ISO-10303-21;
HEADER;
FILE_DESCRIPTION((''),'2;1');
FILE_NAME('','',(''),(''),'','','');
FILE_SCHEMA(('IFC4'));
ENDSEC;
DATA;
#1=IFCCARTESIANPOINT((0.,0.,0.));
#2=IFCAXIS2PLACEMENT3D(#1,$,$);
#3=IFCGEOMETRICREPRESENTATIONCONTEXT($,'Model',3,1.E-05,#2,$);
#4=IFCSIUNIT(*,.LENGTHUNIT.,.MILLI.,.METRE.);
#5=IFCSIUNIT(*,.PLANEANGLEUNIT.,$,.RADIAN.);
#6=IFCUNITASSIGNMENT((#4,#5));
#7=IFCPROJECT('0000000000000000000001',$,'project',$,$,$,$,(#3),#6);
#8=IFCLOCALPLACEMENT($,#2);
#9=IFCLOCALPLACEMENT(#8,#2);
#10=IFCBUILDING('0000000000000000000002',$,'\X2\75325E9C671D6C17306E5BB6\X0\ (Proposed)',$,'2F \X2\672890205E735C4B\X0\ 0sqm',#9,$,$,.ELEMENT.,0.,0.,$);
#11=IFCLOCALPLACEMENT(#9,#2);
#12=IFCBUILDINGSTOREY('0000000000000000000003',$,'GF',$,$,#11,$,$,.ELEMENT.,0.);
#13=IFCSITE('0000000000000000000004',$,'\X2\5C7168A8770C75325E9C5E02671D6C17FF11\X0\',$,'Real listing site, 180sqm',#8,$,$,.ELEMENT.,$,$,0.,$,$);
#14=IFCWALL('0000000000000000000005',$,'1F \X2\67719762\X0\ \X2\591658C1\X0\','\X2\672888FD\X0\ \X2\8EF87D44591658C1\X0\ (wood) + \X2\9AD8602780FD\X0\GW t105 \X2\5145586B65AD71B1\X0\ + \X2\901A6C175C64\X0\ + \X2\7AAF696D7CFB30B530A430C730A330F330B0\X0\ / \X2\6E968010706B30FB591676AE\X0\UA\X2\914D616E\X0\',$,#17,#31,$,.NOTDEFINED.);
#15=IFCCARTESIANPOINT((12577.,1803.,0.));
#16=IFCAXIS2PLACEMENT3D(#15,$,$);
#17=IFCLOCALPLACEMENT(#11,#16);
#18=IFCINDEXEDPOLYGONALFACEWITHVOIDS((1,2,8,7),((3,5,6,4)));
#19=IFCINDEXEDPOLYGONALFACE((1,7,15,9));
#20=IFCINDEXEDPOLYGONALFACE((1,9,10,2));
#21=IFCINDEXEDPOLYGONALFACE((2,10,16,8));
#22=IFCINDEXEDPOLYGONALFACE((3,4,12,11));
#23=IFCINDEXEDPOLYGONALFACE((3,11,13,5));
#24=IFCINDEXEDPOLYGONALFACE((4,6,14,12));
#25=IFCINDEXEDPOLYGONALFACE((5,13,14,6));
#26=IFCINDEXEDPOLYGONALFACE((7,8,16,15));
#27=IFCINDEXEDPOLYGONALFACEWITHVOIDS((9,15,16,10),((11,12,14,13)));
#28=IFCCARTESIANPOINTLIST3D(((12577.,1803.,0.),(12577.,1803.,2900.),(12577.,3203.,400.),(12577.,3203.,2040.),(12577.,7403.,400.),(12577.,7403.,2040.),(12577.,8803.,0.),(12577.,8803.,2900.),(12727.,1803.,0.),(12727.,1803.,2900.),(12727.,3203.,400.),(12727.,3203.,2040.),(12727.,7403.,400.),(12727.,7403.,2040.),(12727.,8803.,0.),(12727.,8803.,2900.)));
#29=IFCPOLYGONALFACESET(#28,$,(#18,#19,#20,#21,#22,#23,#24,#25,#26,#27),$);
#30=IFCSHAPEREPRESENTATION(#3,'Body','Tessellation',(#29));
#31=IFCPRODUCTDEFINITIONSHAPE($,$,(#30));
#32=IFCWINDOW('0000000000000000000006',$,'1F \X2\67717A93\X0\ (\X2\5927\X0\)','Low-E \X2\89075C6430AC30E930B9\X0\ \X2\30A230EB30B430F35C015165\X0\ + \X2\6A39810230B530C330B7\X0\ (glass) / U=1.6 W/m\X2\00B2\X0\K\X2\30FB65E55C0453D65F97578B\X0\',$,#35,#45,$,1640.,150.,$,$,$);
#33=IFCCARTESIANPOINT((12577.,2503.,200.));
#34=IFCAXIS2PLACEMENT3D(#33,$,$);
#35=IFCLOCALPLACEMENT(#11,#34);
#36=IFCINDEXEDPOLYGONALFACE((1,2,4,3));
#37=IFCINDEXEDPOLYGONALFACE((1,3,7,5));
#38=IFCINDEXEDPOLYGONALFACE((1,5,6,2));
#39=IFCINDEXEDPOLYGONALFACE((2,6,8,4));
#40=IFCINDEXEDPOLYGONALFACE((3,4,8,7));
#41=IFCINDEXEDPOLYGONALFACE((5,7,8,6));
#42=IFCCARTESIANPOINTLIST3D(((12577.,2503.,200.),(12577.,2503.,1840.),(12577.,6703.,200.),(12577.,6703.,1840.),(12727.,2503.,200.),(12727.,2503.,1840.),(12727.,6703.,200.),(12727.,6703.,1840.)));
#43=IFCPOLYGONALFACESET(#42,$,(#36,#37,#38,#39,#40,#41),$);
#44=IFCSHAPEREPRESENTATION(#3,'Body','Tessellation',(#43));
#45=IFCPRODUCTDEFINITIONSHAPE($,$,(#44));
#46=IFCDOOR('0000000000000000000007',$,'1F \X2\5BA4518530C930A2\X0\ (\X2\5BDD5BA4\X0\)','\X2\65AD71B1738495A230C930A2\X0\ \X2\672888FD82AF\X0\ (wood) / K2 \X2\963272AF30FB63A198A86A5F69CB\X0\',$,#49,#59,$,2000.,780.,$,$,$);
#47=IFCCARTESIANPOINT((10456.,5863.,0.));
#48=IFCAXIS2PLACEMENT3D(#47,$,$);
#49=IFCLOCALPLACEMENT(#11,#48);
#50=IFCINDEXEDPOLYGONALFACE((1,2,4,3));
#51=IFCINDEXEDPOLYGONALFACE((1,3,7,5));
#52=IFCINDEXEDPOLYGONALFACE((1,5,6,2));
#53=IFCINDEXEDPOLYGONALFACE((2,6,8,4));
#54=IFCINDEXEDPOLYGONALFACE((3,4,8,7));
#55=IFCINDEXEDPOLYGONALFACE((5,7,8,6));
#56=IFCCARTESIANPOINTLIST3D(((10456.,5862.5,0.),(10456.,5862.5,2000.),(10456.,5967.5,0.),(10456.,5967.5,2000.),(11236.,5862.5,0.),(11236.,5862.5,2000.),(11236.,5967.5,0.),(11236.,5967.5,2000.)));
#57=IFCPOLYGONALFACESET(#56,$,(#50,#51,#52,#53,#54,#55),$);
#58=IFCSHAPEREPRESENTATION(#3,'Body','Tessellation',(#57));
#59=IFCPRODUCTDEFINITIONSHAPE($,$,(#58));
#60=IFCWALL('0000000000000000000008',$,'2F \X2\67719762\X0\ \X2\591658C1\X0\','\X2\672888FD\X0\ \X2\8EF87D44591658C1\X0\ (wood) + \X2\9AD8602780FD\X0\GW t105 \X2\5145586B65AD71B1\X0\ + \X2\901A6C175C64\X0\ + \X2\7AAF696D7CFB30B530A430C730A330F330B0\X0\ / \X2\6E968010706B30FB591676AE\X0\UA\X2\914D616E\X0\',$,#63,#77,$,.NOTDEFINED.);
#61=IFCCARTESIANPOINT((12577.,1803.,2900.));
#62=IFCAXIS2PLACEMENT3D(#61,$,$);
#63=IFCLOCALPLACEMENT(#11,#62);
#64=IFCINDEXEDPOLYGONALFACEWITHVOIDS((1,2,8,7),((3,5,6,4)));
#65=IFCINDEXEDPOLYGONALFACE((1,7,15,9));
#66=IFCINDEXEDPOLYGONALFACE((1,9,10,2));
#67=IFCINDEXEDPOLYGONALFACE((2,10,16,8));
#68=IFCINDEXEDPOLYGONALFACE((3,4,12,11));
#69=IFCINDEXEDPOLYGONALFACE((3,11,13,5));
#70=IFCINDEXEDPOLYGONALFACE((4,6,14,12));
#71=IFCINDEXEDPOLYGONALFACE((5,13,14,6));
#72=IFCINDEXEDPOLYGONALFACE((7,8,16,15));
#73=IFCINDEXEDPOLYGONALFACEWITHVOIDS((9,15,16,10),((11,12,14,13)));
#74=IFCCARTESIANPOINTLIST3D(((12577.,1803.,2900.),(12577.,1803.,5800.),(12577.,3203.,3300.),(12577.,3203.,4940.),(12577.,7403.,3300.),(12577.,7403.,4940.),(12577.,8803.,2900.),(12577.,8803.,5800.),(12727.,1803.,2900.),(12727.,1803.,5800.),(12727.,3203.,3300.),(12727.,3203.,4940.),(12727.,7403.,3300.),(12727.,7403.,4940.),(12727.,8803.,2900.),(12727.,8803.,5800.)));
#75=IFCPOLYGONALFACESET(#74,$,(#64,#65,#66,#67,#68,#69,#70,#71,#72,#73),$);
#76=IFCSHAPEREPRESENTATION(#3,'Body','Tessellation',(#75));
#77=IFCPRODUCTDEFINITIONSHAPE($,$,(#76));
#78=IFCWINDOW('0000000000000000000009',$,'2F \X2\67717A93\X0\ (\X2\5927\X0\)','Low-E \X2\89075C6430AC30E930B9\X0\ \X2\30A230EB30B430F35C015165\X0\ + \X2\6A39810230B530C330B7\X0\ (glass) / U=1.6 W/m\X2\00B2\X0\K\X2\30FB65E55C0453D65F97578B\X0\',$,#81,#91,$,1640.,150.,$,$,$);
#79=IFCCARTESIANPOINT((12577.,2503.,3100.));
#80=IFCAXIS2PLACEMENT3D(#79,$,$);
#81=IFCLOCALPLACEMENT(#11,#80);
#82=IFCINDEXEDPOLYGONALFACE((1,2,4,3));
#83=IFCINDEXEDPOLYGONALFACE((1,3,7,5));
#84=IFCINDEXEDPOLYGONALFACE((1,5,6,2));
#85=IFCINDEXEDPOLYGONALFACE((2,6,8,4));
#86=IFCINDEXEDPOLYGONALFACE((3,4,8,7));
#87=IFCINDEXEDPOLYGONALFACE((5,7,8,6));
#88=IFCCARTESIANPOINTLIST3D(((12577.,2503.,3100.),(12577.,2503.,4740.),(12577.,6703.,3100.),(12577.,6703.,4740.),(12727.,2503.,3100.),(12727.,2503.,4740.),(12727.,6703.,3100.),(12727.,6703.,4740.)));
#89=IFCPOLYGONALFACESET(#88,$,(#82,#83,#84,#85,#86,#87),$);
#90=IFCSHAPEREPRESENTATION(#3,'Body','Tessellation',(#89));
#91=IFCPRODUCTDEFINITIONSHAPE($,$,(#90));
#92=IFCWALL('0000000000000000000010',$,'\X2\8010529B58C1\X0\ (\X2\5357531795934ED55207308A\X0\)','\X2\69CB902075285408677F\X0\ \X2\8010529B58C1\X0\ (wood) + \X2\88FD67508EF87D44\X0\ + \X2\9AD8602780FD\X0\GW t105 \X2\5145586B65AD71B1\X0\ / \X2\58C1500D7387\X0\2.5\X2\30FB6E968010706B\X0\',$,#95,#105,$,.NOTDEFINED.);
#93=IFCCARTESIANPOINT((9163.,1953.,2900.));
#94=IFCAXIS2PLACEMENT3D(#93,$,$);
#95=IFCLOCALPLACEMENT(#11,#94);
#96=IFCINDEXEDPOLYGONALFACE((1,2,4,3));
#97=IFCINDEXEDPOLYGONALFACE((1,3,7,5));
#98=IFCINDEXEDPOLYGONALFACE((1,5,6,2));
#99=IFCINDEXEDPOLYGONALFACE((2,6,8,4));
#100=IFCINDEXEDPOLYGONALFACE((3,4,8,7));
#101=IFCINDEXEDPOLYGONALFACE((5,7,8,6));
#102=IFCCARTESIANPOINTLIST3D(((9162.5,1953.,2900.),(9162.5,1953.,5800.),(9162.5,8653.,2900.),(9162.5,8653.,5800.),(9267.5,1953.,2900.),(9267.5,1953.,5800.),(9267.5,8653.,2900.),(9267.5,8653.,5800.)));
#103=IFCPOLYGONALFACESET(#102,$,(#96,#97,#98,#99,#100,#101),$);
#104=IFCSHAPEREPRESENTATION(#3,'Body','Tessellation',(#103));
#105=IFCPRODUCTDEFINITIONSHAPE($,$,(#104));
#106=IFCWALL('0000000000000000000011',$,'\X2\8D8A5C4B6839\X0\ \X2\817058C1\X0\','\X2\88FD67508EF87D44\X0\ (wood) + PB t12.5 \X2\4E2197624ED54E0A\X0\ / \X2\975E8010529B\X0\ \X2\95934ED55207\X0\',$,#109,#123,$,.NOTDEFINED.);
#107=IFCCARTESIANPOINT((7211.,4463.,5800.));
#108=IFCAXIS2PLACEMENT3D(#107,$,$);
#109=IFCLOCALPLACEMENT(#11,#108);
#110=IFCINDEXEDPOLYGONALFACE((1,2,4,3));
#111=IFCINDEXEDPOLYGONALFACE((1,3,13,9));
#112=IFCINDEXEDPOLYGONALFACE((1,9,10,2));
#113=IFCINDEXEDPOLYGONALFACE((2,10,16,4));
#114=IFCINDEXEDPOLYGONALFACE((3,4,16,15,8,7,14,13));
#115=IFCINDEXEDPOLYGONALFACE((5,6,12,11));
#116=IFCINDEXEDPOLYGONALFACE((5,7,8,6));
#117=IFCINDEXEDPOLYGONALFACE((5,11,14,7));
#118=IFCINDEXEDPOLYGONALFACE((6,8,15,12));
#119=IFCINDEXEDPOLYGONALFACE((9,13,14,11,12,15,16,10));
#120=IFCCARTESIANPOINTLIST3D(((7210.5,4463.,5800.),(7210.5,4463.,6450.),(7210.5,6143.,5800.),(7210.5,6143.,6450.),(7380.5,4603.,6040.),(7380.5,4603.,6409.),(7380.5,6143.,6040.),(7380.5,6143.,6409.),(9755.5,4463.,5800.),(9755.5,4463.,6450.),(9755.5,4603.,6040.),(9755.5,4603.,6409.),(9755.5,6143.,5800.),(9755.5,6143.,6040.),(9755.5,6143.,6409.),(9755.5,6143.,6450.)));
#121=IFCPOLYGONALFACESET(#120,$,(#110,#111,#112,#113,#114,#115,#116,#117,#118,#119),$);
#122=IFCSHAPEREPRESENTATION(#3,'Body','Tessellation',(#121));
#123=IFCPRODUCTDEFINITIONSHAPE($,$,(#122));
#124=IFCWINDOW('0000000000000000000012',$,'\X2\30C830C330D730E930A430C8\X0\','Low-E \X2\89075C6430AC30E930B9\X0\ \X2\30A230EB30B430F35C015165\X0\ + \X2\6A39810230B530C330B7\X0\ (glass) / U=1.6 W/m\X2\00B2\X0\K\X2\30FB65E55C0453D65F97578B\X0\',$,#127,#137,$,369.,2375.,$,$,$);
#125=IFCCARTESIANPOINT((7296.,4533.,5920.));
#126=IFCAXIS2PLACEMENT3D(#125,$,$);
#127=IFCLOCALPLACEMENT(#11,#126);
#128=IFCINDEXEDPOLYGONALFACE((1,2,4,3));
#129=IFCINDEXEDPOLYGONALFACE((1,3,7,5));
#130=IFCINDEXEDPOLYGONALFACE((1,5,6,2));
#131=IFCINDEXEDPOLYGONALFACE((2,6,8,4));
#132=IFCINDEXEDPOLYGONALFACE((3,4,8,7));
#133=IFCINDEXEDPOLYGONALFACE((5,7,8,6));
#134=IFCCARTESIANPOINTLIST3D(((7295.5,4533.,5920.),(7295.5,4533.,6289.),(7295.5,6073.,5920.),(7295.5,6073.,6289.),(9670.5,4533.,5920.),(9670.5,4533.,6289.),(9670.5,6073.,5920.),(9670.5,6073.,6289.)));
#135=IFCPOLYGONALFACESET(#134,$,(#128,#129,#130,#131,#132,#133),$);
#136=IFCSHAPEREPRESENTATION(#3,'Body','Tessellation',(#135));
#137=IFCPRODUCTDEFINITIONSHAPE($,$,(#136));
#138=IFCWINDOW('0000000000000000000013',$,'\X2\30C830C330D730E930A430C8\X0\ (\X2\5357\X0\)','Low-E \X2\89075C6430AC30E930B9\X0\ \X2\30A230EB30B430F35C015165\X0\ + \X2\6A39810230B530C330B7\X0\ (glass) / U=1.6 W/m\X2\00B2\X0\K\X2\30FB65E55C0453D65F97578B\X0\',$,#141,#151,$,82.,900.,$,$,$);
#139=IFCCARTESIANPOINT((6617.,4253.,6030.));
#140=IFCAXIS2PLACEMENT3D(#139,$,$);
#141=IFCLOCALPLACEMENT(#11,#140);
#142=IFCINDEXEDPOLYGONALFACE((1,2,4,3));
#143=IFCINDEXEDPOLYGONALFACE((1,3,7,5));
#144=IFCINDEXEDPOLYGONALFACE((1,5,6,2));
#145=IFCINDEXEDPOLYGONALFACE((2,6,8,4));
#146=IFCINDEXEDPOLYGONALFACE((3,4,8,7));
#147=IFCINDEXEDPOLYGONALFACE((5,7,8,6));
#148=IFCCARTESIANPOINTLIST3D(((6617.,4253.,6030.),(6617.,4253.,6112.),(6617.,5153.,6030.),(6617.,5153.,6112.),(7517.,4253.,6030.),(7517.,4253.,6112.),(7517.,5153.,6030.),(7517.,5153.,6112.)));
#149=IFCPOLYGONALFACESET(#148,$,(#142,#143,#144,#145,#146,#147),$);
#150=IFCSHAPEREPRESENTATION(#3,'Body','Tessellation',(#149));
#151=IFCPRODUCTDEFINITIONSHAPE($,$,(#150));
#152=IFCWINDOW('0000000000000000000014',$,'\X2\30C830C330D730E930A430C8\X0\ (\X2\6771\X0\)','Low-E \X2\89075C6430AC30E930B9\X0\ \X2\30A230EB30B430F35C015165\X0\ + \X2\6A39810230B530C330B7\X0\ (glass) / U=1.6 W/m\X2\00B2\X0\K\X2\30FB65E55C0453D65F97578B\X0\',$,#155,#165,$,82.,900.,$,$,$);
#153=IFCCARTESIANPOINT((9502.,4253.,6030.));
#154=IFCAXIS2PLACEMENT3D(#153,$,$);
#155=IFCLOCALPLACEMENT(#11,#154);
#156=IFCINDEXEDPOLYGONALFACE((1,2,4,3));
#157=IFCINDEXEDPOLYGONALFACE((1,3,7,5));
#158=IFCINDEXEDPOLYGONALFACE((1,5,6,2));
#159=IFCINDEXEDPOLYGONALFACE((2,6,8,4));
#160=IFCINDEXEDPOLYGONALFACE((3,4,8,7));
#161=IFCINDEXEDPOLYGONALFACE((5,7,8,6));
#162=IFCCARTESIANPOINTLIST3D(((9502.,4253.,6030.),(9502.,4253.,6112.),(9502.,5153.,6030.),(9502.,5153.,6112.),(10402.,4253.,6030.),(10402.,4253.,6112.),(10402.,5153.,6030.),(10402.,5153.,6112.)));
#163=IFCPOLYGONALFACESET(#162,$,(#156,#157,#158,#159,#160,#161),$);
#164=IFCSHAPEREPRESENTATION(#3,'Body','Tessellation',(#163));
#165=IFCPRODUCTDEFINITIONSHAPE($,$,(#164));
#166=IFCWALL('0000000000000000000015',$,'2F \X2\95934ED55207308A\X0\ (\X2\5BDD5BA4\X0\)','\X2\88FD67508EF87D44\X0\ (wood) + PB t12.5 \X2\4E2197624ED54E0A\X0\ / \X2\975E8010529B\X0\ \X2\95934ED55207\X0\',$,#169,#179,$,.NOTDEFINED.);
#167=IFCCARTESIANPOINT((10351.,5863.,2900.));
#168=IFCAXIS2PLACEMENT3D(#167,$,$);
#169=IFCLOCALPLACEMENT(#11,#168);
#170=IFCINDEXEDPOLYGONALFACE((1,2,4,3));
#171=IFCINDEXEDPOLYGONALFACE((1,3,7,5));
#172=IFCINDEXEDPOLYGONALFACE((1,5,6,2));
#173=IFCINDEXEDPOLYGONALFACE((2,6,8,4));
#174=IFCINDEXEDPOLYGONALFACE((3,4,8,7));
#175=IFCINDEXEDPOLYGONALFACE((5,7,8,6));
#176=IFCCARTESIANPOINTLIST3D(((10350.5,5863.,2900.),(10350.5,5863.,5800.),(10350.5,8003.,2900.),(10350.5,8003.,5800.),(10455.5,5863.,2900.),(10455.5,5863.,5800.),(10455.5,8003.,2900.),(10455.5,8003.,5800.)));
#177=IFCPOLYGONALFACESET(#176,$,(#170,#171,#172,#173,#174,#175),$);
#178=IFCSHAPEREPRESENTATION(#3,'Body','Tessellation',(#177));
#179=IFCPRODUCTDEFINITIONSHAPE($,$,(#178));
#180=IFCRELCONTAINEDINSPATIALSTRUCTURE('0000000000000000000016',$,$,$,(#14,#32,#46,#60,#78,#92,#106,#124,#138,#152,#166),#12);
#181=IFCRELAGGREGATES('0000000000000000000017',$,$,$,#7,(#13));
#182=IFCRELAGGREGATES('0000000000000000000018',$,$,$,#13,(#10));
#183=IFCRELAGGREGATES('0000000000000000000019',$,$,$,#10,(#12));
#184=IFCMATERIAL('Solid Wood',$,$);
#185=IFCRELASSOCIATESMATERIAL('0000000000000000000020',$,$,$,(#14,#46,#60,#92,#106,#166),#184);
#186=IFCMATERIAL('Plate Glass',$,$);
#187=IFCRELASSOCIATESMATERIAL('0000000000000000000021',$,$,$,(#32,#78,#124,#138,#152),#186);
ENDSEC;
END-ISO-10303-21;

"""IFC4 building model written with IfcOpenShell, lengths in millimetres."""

from ifc_helpers import new_model, si_unit, frame, frame_2d, origin, place, context, project, spatial, rectangle, extrude, material, element, fill, save


model = new_model("IFC4")

# Units and contexts
model_context = context("Model", 3, precision=1e-05, world=origin())
ifc_project = project(units=[si_unit("LENGTHUNIT", "METRE", prefix="MILLI"), si_unit("PLANEANGLEUNIT", "RADIAN")], contexts=[model_context])

# Site, building, storey
site_placement = place(None, origin())
site = spatial("IfcSite", under=ifc_project, at=site_placement, Name="山梨県甲府市朝気１", ObjectType="Real listing site, 180sqm", CompositionType="ELEMENT", RefElevation=0.0)
building_placement = place(site_placement, origin())
building = spatial("IfcBuilding", under=site, at=building_placement, Name="甲府朝気の家 (Proposed)", ObjectType="2F 木造平屋 0sqm", CompositionType="ELEMENT", ElevationOfRefHeight=0.0, ElevationOfTerrain=0.0)
storey_placement = place(building_placement, origin())
storey = spatial("IfcBuildingStorey", under=building, at=storey_placement, Name="GF", CompositionType="ELEMENT", Elevation=0.0)

# Wall, opening, window
ifc_material_1 = material(Name="Solid Wood")
wall_1_placement = place(storey_placement, frame((12577.0, 1803.0, 0.0)))
wall_1 = element("IfcWall", 1, at=wall_1_placement, inside=storey, material=ifc_material_1, Name="1F 東面 外壁", Description="木製 軸組外壁 (wood) + 高性能GW t105 充填断熱 + 通気層 + 窯業系サイディング / 準耐火・外皮UA配慮", PredefinedType="NOTDEFINED", context=model_context, shape_type="SweptSolid", body=[
    extrude(rectangle(XDim=150.0, YDim=7000.0, at=frame_2d((75.0, 3500.0))), frame((12577.0, 1803.0, 0.0)), (0.0, 0.0, 1.0), 2900.0),
])
opening_1_placement = place(storey_placement, frame((12577.0, 2503.0, 200.0)))
opening_1 = element("IfcOpeningElement", 2, at=opening_1_placement, cuts=wall_1, PredefinedType="NOTDEFINED", context=model_context, shape_type="SweptSolid", body=[
    extrude(rectangle(XDim=150.0, YDim=4200.0, at=frame_2d((75.0, 2100.0))), frame((12577.0, 2503.0, 200.0)), (0.0, 0.0, 1.0), 1640.0),
])
ifc_material_2 = material(Name="Plate Glass")
window_1_placement = place(storey_placement, frame((12577.0, 2503.0, 200.0)))
window_1 = element("IfcWindow", 3, at=window_1_placement, inside=storey, material=ifc_material_2, Name="1F 東窓 (大)", Description="Low-E 複層ガラス アルゴン封入 + 樹脂サッシ (glass) / U=1.6 W/m²K・日射取得型", OverallHeight=1640.0, OverallWidth=150.0, context=model_context, shape_type="SweptSolid", body=[
    extrude(rectangle(XDim=150.0, YDim=4200.0, at=frame_2d((75.0, 2100.0))), frame((12577.0, 2503.0, 200.0)), (0.0, 0.0, 1.0), 1640.0),
])
fill(opening_1, window_1)

# Door
door_1_placement = place(storey_placement, frame((10456.0, 5863.0, 0.0)))
element("IfcDoor", 4, at=door_1_placement, inside=storey, material=ifc_material_1, Name="1F 室内ドア (寝室)", Description="断熱玄関ドア 木製芯 (wood) / K2 防犯・採風機構", OverallHeight=2000.0, OverallWidth=780.0, context=model_context, shape_type="SweptSolid", body=[
    extrude(rectangle(XDim=780.0, YDim=105.0, at=frame_2d((390.0, 52.0))), frame((10456.0, 5863.0, 0.0)), (0.0, 0.0, 1.0), 2000.0),
])

# Wall, opening, window
wall_2_placement = place(storey_placement, frame((12577.0, 1803.0, 2900.0)))
wall_2 = element("IfcWall", 5, at=wall_2_placement, inside=storey, material=ifc_material_1, Name="2F 東面 外壁", Description="木製 軸組外壁 (wood) + 高性能GW t105 充填断熱 + 通気層 + 窯業系サイディング / 準耐火・外皮UA配慮", PredefinedType="NOTDEFINED", context=model_context, shape_type="SweptSolid", body=[
    extrude(rectangle(XDim=150.0, YDim=7000.0, at=frame_2d((75.0, 3500.0))), frame((12577.0, 1803.0, 2900.0)), (0.0, 0.0, 1.0), 2900.0),
])
opening_2_placement = place(storey_placement, frame((12577.0, 2503.0, 3100.0)))
opening_2 = element("IfcOpeningElement", 6, at=opening_2_placement, cuts=wall_2, PredefinedType="NOTDEFINED", context=model_context, shape_type="SweptSolid", body=[
    extrude(rectangle(XDim=150.0, YDim=4200.0, at=frame_2d((75.0, 2100.0))), frame((12577.0, 2503.0, 3100.0)), (0.0, 0.0, 1.0), 1640.0),
])
window_2_placement = place(storey_placement, frame((12577.0, 2503.0, 3100.0)))
window_2 = element("IfcWindow", 7, at=window_2_placement, inside=storey, material=ifc_material_2, Name="2F 東窓 (大)", Description="Low-E 複層ガラス アルゴン封入 + 樹脂サッシ (glass) / U=1.6 W/m²K・日射取得型", OverallHeight=1640.0, OverallWidth=150.0, context=model_context, shape_type="SweptSolid", body=[
    extrude(rectangle(XDim=150.0, YDim=4200.0, at=frame_2d((75.0, 2100.0))), frame((12577.0, 2503.0, 3100.0)), (0.0, 0.0, 1.0), 1640.0),
])
fill(opening_2, window_2)

# Wall
wall_3_placement = place(storey_placement, frame((9163.0, 1953.0, 2900.0)))
element("IfcWall", 8, at=wall_3_placement, inside=storey, material=ifc_material_1, Name="耐力壁 (南北間仕切り)", Description="構造用合板 耐力壁 (wood) + 製材軸組 + 高性能GW t105 充填断熱 / 壁倍率2.5・準耐火", PredefinedType="NOTDEFINED", context=model_context, shape_type="SweptSolid", body=[
    extrude(rectangle(XDim=105.0, YDim=6700.0, at=frame_2d((52.0, 3350.0))), frame((9163.0, 1953.0, 2900.0)), (0.0, 0.0, 1.0), 2900.0),
])

# Wall, openings, windows
wall_4_placement = place(storey_placement, frame((7211.0, 4463.0, 5800.0)))
wall_4 = element("IfcWall", 9, at=wall_4_placement, inside=storey, material=ifc_material_1, Name="越屋根 腰壁", Description="製材軸組 (wood) + PB t12.5 両面仕上 / 非耐力 間仕切", PredefinedType="NOTDEFINED", context=model_context, shape_type="SweptSolid", body=[
    extrude(rectangle(XDim=2545.0, YDim=1680.0, at=frame_2d((1272.0, 840.0))), frame((7211.0, 4463.0, 5800.0)), (0.0, 0.0, 1.0), 650.0),
])
opening_3_placement = place(storey_placement, frame((7296.0, 4533.0, 5920.0)))
opening_3 = element("IfcOpeningElement", 10, at=opening_3_placement, cuts=wall_4, PredefinedType="NOTDEFINED", context=model_context, shape_type="SweptSolid", body=[
    extrude(rectangle(XDim=2375.0, YDim=1540.0, at=frame_2d((1187.0, 770.0))), frame((7296.0, 4533.0, 5920.0)), (0.0, 0.0, 1.0), 369.0),
])
opening_4_placement = place(storey_placement, frame((6617.0, 4253.0, 6030.0)))
opening_4 = element("IfcOpeningElement", 11, at=opening_4_placement, cuts=wall_4, PredefinedType="NOTDEFINED", context=model_context, shape_type="SweptSolid", body=[
    extrude(rectangle(XDim=900.0, YDim=900.0, at=frame_2d((450.0, 450.0))), frame((6617.0, 4253.0, 6030.0)), (0.0, 0.0, 1.0), 82.0),
])
opening_5_placement = place(storey_placement, frame((9502.0, 4253.0, 6030.0)))
opening_5 = element("IfcOpeningElement", 12, at=opening_5_placement, cuts=wall_4, PredefinedType="NOTDEFINED", context=model_context, shape_type="SweptSolid", body=[
    extrude(rectangle(XDim=900.0, YDim=900.0, at=frame_2d((450.0, 450.0))), frame((9502.0, 4253.0, 6030.0)), (0.0, 0.0, 1.0), 82.0),
])
window_3_placement = place(storey_placement, frame((7296.0, 4533.0, 5920.0)))
window_3 = element("IfcWindow", 13, at=window_3_placement, inside=storey, material=ifc_material_2, Name="トップライト", Description="Low-E 複層ガラス アルゴン封入 + 樹脂サッシ (glass) / U=1.6 W/m²K・日射取得型", OverallHeight=369.0, OverallWidth=2375.0, context=model_context, shape_type="SweptSolid", body=[
    extrude(rectangle(XDim=2375.0, YDim=1540.0, at=frame_2d((1187.0, 770.0))), frame((7296.0, 4533.0, 5920.0)), (0.0, 0.0, 1.0), 369.0),
])
fill(opening_3, window_3)
window_4_placement = place(storey_placement, frame((6617.0, 4253.0, 6030.0)))
window_4 = element("IfcWindow", 14, at=window_4_placement, inside=storey, material=ifc_material_2, Name="トップライト (南)", Description="Low-E 複層ガラス アルゴン封入 + 樹脂サッシ (glass) / U=1.6 W/m²K・日射取得型", OverallHeight=82.0, OverallWidth=900.0, context=model_context, shape_type="SweptSolid", body=[
    extrude(rectangle(XDim=900.0, YDim=900.0, at=frame_2d((450.0, 450.0))), frame((6617.0, 4253.0, 6030.0)), (0.0, 0.0, 1.0), 82.0),
])
fill(opening_4, window_4)
window_5_placement = place(storey_placement, frame((9502.0, 4253.0, 6030.0)))
window_5 = element("IfcWindow", 15, at=window_5_placement, inside=storey, material=ifc_material_2, Name="トップライト (東)", Description="Low-E 複層ガラス アルゴン封入 + 樹脂サッシ (glass) / U=1.6 W/m²K・日射取得型", OverallHeight=82.0, OverallWidth=900.0, context=model_context, shape_type="SweptSolid", body=[
    extrude(rectangle(XDim=900.0, YDim=900.0, at=frame_2d((450.0, 450.0))), frame((9502.0, 4253.0, 6030.0)), (0.0, 0.0, 1.0), 82.0),
])
fill(opening_5, window_5)

# Wall
wall_5_placement = place(storey_placement, frame((10351.0, 5863.0, 2900.0)))
element("IfcWall", 16, at=wall_5_placement, inside=storey, material=ifc_material_1, Name="2F 間仕切り (寝室)", Description="製材軸組 (wood) + PB t12.5 両面仕上 / 非耐力 間仕切", PredefinedType="NOTDEFINED", context=model_context, shape_type="SweptSolid", body=[
    extrude(rectangle(XDim=105.0, YDim=2140.0, at=frame_2d((52.0, 1070.0))), frame((10351.0, 5863.0, 2900.0)), (0.0, 0.0, 1.0), 2900.0),
])

save(model, "model.ifc")
